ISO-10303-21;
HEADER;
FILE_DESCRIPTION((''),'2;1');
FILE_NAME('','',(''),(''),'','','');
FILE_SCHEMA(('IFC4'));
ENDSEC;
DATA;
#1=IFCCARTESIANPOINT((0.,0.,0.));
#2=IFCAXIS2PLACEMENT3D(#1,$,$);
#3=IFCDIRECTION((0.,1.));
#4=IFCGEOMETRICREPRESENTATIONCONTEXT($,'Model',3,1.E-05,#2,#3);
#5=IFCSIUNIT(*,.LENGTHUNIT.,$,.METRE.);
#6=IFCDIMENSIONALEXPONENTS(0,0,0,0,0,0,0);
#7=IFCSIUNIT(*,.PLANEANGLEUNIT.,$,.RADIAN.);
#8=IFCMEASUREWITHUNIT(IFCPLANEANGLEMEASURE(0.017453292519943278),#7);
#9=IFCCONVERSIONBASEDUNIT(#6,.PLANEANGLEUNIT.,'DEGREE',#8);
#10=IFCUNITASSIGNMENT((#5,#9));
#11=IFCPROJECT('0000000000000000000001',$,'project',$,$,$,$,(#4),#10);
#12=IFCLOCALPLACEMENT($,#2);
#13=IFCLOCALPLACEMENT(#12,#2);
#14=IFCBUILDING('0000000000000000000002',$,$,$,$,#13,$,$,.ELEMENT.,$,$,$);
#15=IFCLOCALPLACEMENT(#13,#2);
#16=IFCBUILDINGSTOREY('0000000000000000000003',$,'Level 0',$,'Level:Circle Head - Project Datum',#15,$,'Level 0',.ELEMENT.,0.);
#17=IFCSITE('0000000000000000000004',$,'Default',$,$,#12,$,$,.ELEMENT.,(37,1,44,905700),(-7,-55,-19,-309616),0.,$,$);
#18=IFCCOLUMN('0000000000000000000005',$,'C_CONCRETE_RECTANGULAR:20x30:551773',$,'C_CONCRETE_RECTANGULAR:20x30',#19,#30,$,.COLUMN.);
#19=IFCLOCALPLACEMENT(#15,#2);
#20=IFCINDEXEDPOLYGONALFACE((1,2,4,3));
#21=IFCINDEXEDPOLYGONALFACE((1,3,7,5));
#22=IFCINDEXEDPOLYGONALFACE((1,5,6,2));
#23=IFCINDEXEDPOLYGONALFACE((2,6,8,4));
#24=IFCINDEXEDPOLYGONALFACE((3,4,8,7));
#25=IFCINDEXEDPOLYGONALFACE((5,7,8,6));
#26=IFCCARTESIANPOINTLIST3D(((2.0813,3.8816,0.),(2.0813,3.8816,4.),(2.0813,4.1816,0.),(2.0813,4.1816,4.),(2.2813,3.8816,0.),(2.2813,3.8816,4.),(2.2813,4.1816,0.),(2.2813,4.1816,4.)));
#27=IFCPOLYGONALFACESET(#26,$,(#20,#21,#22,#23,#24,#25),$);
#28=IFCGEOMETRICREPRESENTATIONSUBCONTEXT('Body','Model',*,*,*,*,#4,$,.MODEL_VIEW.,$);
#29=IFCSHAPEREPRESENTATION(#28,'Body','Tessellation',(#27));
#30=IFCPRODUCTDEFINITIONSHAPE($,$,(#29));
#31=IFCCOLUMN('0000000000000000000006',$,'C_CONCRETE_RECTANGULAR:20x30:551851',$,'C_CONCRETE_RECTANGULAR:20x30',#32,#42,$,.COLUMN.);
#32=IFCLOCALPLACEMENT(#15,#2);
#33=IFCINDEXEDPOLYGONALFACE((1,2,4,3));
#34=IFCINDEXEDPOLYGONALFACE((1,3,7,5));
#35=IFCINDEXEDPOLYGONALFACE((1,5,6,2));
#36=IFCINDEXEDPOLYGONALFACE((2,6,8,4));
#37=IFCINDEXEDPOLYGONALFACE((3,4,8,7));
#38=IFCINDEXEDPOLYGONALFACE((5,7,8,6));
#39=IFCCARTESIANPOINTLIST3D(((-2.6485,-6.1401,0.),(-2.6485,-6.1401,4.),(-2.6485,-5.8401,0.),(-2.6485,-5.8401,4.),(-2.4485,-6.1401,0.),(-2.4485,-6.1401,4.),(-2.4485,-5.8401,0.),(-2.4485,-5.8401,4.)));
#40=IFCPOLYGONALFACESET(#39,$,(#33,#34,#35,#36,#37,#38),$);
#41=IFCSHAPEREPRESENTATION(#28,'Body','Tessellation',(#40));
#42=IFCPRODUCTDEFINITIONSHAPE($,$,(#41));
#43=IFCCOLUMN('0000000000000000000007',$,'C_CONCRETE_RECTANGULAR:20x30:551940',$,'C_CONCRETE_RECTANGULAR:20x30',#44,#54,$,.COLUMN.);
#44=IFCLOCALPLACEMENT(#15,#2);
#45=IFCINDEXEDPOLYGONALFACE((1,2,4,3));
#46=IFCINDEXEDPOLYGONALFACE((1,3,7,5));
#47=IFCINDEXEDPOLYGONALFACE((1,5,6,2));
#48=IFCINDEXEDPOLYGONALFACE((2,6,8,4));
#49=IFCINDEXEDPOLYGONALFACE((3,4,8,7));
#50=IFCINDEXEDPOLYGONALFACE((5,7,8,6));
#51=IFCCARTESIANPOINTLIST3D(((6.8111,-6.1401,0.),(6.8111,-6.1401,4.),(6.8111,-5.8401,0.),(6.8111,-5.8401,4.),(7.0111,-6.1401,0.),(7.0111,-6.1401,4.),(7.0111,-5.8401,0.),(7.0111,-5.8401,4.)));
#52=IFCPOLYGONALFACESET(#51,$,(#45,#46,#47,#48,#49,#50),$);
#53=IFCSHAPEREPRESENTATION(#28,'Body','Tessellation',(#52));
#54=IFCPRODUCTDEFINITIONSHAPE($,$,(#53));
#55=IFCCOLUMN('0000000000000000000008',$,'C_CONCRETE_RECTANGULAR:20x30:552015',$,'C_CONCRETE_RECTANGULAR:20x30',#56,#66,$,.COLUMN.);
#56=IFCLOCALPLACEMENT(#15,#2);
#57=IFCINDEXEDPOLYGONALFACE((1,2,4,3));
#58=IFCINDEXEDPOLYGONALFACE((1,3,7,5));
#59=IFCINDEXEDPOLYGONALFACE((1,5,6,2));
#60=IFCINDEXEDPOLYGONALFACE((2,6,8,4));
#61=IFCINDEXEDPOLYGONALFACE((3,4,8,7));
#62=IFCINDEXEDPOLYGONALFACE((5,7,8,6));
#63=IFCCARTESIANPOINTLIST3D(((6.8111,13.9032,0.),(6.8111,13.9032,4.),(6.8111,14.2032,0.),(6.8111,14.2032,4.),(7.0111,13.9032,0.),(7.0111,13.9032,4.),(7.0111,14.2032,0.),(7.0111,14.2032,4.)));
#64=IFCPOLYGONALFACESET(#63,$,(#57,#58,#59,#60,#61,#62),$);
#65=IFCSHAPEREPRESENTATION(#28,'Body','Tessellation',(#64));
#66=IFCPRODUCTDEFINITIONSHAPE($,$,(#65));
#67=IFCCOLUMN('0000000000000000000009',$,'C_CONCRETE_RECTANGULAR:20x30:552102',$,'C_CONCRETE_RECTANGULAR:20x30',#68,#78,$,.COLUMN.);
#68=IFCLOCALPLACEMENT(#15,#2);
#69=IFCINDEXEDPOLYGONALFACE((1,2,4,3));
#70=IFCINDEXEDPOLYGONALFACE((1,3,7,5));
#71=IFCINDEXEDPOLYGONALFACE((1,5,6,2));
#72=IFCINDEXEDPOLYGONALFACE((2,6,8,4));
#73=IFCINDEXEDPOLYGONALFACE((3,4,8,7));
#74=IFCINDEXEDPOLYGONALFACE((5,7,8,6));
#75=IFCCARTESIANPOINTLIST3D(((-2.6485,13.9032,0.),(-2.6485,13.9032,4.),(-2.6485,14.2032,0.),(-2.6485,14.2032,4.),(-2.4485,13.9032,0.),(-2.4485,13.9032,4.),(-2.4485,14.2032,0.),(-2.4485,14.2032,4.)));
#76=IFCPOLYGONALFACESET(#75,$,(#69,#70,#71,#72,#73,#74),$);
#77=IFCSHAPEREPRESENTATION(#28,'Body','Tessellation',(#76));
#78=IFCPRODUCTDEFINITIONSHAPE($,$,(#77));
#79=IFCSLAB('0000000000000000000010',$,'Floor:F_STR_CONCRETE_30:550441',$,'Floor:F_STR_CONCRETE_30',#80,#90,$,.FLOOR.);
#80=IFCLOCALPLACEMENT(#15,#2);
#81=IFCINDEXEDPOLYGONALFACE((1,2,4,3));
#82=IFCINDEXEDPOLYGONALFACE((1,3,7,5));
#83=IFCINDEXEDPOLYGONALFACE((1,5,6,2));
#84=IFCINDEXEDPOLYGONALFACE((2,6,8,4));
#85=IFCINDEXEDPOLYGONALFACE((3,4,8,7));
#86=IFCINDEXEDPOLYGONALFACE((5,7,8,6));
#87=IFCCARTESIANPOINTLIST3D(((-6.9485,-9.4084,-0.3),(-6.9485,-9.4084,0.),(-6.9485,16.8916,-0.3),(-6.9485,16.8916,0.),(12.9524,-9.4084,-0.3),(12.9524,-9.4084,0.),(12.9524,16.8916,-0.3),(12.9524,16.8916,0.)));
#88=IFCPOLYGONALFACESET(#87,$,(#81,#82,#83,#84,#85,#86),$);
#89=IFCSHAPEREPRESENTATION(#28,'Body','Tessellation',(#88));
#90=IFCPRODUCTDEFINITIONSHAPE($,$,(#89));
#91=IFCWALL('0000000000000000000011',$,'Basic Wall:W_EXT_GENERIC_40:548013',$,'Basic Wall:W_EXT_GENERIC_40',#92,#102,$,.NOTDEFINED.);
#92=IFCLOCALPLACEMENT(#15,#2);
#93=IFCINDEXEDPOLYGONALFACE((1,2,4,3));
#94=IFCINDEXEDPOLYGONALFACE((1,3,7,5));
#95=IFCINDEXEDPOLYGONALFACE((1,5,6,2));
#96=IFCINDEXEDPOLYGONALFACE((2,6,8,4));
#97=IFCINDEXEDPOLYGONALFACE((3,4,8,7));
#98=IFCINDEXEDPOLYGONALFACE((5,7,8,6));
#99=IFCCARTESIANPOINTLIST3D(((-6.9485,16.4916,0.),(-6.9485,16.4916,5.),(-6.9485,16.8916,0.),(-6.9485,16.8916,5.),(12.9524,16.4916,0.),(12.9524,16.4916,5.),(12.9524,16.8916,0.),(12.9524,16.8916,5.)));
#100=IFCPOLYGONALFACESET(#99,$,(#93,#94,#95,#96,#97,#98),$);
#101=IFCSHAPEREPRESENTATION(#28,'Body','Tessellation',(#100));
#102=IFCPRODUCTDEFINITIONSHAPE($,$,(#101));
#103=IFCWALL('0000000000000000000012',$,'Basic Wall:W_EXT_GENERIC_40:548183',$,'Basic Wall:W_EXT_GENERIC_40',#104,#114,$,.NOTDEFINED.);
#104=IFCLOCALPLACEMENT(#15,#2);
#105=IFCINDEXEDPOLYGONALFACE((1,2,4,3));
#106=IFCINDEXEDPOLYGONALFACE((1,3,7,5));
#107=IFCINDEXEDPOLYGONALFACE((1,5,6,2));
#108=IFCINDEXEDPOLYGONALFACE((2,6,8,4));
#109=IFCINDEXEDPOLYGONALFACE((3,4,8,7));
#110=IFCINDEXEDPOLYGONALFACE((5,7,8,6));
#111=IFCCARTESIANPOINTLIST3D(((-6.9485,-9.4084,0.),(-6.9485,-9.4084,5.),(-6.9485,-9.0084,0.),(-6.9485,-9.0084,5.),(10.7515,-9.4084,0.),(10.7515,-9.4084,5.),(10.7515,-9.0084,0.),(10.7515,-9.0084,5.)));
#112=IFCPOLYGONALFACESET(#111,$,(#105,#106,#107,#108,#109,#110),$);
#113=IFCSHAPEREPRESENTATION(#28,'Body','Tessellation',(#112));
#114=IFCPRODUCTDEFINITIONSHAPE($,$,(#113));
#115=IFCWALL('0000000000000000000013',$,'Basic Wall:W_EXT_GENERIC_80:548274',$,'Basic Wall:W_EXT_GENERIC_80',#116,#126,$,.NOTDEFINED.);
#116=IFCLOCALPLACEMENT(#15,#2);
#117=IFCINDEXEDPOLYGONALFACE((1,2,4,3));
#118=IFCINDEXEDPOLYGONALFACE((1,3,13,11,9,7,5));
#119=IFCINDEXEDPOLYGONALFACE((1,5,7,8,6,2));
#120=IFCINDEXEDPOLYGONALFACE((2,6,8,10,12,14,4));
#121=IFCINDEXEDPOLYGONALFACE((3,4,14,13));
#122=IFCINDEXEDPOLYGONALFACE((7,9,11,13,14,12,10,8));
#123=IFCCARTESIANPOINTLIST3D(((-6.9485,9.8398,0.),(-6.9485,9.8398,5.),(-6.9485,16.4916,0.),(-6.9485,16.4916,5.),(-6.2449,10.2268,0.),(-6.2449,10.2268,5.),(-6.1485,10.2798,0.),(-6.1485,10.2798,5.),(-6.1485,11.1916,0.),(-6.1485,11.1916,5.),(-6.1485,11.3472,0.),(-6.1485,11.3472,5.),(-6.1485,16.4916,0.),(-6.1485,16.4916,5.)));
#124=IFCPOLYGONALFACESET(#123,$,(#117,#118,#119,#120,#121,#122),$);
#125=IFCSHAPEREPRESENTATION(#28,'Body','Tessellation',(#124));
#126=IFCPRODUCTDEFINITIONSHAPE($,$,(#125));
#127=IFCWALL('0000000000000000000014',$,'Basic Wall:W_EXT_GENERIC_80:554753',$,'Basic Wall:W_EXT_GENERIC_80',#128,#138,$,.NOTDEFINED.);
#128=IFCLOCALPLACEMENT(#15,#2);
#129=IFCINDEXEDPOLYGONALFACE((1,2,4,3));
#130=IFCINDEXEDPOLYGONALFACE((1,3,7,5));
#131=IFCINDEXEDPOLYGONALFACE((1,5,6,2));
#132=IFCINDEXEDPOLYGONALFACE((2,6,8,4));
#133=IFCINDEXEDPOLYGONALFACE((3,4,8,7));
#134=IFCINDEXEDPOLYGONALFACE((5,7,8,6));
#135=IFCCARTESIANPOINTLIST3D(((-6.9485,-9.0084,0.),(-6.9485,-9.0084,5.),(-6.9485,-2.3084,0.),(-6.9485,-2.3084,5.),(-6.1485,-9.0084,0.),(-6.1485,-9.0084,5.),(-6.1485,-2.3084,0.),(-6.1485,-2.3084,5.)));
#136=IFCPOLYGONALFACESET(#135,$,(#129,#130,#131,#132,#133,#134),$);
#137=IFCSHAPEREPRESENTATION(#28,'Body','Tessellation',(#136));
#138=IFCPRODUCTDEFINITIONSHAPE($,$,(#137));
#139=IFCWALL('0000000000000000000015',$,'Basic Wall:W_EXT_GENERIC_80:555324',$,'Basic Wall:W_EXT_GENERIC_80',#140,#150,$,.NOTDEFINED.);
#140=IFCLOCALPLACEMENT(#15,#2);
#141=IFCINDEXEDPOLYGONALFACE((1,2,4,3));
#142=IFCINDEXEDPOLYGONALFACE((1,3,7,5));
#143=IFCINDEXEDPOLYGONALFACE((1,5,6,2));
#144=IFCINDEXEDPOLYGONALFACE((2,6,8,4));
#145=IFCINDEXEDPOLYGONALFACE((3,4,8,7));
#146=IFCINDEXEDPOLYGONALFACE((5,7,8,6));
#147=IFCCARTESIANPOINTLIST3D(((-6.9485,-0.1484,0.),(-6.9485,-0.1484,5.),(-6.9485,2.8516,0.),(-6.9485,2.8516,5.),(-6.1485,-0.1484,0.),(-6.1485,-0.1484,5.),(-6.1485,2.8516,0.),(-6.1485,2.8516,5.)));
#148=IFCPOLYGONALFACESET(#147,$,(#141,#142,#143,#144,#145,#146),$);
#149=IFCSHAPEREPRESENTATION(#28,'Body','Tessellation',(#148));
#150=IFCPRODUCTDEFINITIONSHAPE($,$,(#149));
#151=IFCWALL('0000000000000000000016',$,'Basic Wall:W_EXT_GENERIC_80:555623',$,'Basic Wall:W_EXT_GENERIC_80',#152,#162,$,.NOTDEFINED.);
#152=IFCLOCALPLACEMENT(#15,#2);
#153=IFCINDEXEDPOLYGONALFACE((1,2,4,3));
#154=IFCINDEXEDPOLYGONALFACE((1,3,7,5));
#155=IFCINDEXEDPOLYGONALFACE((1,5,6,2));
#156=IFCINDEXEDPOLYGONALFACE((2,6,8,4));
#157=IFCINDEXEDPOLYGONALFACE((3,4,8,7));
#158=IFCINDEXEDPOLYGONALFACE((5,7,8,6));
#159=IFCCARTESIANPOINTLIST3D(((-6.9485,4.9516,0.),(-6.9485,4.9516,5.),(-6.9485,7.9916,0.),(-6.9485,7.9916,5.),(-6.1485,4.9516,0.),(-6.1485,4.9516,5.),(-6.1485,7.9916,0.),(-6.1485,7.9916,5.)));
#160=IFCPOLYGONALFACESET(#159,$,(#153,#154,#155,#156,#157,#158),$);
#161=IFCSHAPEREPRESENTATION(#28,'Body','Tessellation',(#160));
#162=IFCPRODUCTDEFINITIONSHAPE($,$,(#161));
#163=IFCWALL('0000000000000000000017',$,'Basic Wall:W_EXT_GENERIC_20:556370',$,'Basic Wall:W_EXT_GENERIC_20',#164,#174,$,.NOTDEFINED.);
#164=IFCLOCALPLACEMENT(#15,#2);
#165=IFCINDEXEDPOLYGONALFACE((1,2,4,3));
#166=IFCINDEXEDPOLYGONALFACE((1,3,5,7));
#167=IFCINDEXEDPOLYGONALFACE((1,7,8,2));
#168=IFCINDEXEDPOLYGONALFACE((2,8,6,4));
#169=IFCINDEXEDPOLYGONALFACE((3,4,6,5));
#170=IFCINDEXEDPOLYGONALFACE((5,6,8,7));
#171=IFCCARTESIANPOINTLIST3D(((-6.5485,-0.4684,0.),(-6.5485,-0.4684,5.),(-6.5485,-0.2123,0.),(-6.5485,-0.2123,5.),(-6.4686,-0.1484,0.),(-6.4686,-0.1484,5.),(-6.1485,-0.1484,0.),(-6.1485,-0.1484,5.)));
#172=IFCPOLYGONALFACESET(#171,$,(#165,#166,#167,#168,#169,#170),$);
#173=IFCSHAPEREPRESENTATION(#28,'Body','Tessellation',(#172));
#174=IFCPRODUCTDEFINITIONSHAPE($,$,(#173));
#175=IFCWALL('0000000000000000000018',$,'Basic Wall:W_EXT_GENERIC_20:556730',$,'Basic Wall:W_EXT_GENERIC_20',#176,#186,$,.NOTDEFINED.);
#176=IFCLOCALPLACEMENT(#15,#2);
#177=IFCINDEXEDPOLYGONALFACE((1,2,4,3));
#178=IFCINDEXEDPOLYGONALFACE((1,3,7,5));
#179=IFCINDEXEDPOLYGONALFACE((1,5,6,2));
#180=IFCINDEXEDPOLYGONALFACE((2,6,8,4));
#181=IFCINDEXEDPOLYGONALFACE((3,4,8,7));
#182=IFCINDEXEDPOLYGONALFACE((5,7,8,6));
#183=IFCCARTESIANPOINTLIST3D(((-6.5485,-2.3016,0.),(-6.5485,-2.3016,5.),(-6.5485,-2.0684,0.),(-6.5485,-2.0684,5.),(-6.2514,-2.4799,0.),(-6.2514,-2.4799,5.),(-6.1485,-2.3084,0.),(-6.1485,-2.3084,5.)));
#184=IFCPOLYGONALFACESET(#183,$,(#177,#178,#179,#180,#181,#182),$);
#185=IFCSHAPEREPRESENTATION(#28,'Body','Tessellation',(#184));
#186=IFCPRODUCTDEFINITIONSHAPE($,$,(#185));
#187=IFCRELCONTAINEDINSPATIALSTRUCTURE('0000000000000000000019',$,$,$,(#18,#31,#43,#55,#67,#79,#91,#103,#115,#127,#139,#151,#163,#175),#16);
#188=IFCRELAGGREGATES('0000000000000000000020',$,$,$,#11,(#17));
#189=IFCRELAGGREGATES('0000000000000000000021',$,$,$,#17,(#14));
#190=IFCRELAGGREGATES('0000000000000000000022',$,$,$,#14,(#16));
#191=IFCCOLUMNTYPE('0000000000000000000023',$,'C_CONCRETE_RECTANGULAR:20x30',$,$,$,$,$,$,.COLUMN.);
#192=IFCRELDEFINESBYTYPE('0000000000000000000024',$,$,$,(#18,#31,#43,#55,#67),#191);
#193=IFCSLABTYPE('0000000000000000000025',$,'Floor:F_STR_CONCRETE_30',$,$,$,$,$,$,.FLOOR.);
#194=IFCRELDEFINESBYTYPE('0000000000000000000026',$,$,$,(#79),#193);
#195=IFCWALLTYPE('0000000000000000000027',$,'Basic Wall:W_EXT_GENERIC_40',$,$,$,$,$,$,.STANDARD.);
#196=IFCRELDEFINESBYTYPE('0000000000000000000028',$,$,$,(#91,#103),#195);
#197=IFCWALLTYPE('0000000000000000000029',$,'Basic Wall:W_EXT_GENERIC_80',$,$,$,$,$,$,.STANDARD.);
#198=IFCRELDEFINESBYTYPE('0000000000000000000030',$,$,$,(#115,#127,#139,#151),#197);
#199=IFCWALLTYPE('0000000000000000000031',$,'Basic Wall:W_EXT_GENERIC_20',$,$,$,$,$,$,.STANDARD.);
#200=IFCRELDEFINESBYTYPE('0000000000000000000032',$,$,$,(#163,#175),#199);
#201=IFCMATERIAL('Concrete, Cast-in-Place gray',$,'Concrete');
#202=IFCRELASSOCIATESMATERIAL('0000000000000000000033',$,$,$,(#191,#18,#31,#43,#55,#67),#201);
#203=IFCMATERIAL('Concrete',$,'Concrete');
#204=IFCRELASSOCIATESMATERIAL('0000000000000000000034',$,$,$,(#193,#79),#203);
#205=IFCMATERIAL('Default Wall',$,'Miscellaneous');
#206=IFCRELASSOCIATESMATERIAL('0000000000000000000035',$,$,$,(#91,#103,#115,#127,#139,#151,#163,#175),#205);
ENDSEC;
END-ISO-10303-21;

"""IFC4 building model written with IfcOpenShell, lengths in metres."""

from ifc_helpers import new_model, entity, si_unit, converted_unit, direction, frame, origin, place, context, subcontext, project, spatial, indexed_curve, outline, extrude, source, transform, mapped, material, type_object, type_shapes, element, save


model = new_model("IFC4")

# Units and contexts
model_context = context("Model", 3, precision=1e-05, world=origin(), true_north=direction((0.0, 1.0)))
body_context = subcontext(model_context, "Body", "Model", "MODEL_VIEW")
ifc_project = project(units=[si_unit("LENGTHUNIT", "METRE"), converted_unit("PLANEANGLEUNIT", "DEGREE", entity("IfcPlaneAngleMeasure", 0.017453292519943278), si_unit("PLANEANGLEUNIT", "RADIAN"), dimensions=[0, 0, 0, 0, 0, 0, 0])], contexts=[model_context])

# Site, building, storey
site_placement = place(None, origin())
site = spatial("IfcSite", under=ifc_project, at=site_placement, Name="Default", CompositionType="ELEMENT", RefLatitude=(37, 1, 44, 905700), RefLongitude=(-7, -55, -19, -309616), RefElevation=0.0)
building_placement = place(site_placement, origin())
building = spatial("IfcBuilding", under=site, at=building_placement, CompositionType="ELEMENT")
storey_placement = place(building_placement, origin())
storey = spatial("IfcBuildingStorey", under=building, at=storey_placement, Name="Level 0", ObjectType="Level:Circle Head - Project Datum", LongName="Level 0", CompositionType="ELEMENT", Elevation=0.0)

# Columns
ifc_material_1 = material(Name="Concrete, Cast-in-Place gray", Category="Concrete")
column_type = type_object("IfcColumnType", Name="C_CONCRETE_RECTANGULAR:20x30", PredefinedType="COLUMN", material=ifc_material_1)
shared_shape = source(origin(), body_context, "Body", "SweptSolid", [
    extrude(outline(indexed_curve([(-0.1, -0.15), (0.1, -0.15), (0.1, 0.15), (-0.1, 0.15), (-0.1, -0.15)], self_intersect=False)), frame((0.0, 0.0, 0.0), z_axis=(0.0, 0.0, 1.0), x_axis=(-1.0, 0.0, 0.0)), (0.0, 0.0, 1.0), 4.0),
])
type_shapes(column_type, [shared_shape])
for number, where, name in (
    (1, (2.1813, 4.0316, 0.0), "C_CONCRETE_RECTANGULAR:20x30:551773"),
    (2, (-2.5485, -5.9901, 0.0), "C_CONCRETE_RECTANGULAR:20x30:551851"),
    (3, (6.9111, -5.9901, 0.0), "C_CONCRETE_RECTANGULAR:20x30:551940"),
    (4, (6.9111, 14.0532, 0.0), "C_CONCRETE_RECTANGULAR:20x30:552015"),
    (5, (-2.5485, 14.0532, 0.0), "C_CONCRETE_RECTANGULAR:20x30:552102"),
):
    element("IfcColumn", number, at=place(storey_placement, frame(where)), inside=storey, type_object=column_type, material=ifc_material_1, Name=name, ObjectType="C_CONCRETE_RECTANGULAR:20x30", PredefinedType="COLUMN", context=body_context, shape_type="MappedRepresentation", body=[
        mapped(shared_shape, transform((0.0, 0.0, 0.0), scale=1.0)),
    ])

# Slab
ifc_material_2 = material(Name="Concrete", Category="Concrete")
slab_type = type_object("IfcSlabType", Name="Floor:F_STR_CONCRETE_30", PredefinedType="FLOOR", material=ifc_material_2)
slab_placement = place(storey_placement, origin())
element("IfcSlab", 6, at=slab_placement, inside=storey, type_object=slab_type, material=ifc_material_2, Name="Floor:F_STR_CONCRETE_30:550441", ObjectType="Floor:F_STR_CONCRETE_30", PredefinedType="FLOOR", context=body_context, shape_type="SweptSolid", body=[
    extrude(outline(indexed_curve([(-13.15, -9.9504), (13.15, -9.9504), (13.15, 9.9504), (-13.15, 9.9504), (-13.15, -9.9504)], self_intersect=False)), frame((3.0019, 3.7416, 0.0), z_axis=(0.0, 0.0, -1.0), x_axis=(0.0, 1.0, 0.0)), (0.0, 0.0, 1.0), 0.3),
])

# Walls
ifc_material_3 = material(Name="Default Wall", Category="Miscellaneous")
wall_type_1 = type_object("IfcWallType", Name="Basic Wall:W_EXT_GENERIC_40", PredefinedType="STANDARD")
wall_1_placement = place(storey_placement, frame((-6.9485, 16.6916, 0.0)))
element("IfcWall", 7, at=wall_1_placement, inside=storey, type_object=wall_type_1, material=ifc_material_3, Name="Basic Wall:W_EXT_GENERIC_40:548013", ObjectType="Basic Wall:W_EXT_GENERIC_40", PredefinedType="NOTDEFINED", context=body_context, shape_type="SweptSolid", body=[
    extrude(outline(indexed_curve([(19.9008, 0.2), (0.0, 0.2), (0.0, -0.2), (19.9008, -0.2), (19.9008, 0.2)], self_intersect=False)), origin(), (0.0, 0.0, 1.0), 5.0),
])
wall_2_placement = place(storey_placement, frame((10.7515, -9.2084, 0.0), z_axis=(0.0, 0.0, 1.0), x_axis=(-1.0, 0.0, 0.0)))
element("IfcWall", 8, at=wall_2_placement, inside=storey, type_object=wall_type_1, material=ifc_material_3, Name="Basic Wall:W_EXT_GENERIC_40:548183", ObjectType="Basic Wall:W_EXT_GENERIC_40", PredefinedType="NOTDEFINED", context=body_context, shape_type="SweptSolid", body=[
    extrude(outline(indexed_curve([(17.7, 0.2), (0.0, 0.2), (0.0, -0.2), (17.7, -0.2), (17.7, 0.2)], self_intersect=False)), origin(), (0.0, 0.0, 1.0), 5.0),
])
wall_type_2 = type_object("IfcWallType", Name="Basic Wall:W_EXT_GENERIC_80", PredefinedType="STANDARD")
wall_3_placement = place(storey_placement, frame((-6.5485, 16.4916, 0.0), z_axis=(0.0, 0.0, 1.0), x_axis=(0.0, -1.0, 0.0)))
element("IfcWall", 9, at=wall_3_placement, inside=storey, type_object=wall_type_2, material=ifc_material_3, Name="Basic Wall:W_EXT_GENERIC_80:548274", ObjectType="Basic Wall:W_EXT_GENERIC_80", PredefinedType="NOTDEFINED", context=body_context, shape_type="SweptSolid", body=[
    extrude(outline(indexed_curve([(6.6517, -0.4), (6.2648, 0.3036), (6.2117, 0.4), (5.3, 0.4), (5.1444, 0.4), (0.0, 0.4), (0.0, -0.4), (6.6517, -0.4)], self_intersect=False)), origin(), (0.0, 0.0, 1.0), 5.0),
])
wall_4_placement = place(storey_placement, frame((-6.5485, -2.3084, 0.0), z_axis=(0.0, 0.0, 1.0), x_axis=(0.0, -1.0, 0.0)))
element("IfcWall", 10, at=wall_4_placement, inside=storey, type_object=wall_type_2, material=ifc_material_3, Name="Basic Wall:W_EXT_GENERIC_80:554753", ObjectType="Basic Wall:W_EXT_GENERIC_80", PredefinedType="NOTDEFINED", context=body_context, shape_type="SweptSolid", body=[
    extrude(outline(indexed_curve([(6.7, 0.4), (0.0, 0.4), (0.0, -0.4), (6.7, -0.4), (6.7, 0.4)], self_intersect=False)), origin(), (0.0, 0.0, 1.0), 5.0),
])
wall_5_placement = place(storey_placement, frame((-6.5485, 2.8516, 0.0), z_axis=(0.0, 0.0, 1.0), x_axis=(0.0, -1.0, 0.0)))
element("IfcWall", 11, at=wall_5_placement, inside=storey, type_object=wall_type_2, material=ifc_material_3, Name="Basic Wall:W_EXT_GENERIC_80:555324", ObjectType="Basic Wall:W_EXT_GENERIC_80", PredefinedType="NOTDEFINED", context=body_context, shape_type="SweptSolid", body=[
    extrude(outline(indexed_curve([(3.0, 0.4), (0.0, 0.4), (0.0, -0.4), (3.0, -0.4), (3.0, 0.4)], self_intersect=False)), origin(), (0.0, 0.0, 1.0), 5.0),
])
wall_6_placement = place(storey_placement, frame((-6.5485, 7.9916, 0.0), z_axis=(0.0, 0.0, 1.0), x_axis=(0.0, -1.0, 0.0)))
element("IfcWall", 12, at=wall_6_placement, inside=storey, type_object=wall_type_2, material=ifc_material_3, Name="Basic Wall:W_EXT_GENERIC_80:555623", ObjectType="Basic Wall:W_EXT_GENERIC_80", PredefinedType="NOTDEFINED", context=body_context, shape_type="SweptSolid", body=[
    extrude(outline(indexed_curve([(3.04, 0.4), (0.0, 0.4), (0.0, -0.4), (3.04, -0.4), (3.04, 0.4)], self_intersect=False)), origin(), (0.0, 0.0, 1.0), 5.0),
])
wall_type_3 = type_object("IfcWallType", Name="Basic Wall:W_EXT_GENERIC_20", PredefinedType="STANDARD")
wall_7_placement = place(storey_placement, frame((-6.2109, -0.0703, 0.0), z_axis=(0.0, 0.0, 1.0), x_axis=(-0.780869, -0.624695, 0.0)))
element("IfcWall", 13, at=wall_7_placement, inside=storey, type_object=wall_type_3, material=ifc_material_3, Name="Basic Wall:W_EXT_GENERIC_20:556370", ObjectType="Basic Wall:W_EXT_GENERIC_20", PredefinedType="NOTDEFINED", context=body_context, shape_type="SweptSolid", body=[
    extrude(outline(indexed_curve([(0.0, 0.1), (0.25, -0.1), (0.3522, -0.1), (0.5122, 0.1), (0.0, 0.1)], self_intersect=False)), origin(), (0.0, 0.0, 1.0), 5.0),
])
wall_8_placement = place(storey_placement, frame((-6.1999, -2.3942, 0.0), z_axis=(0.0, 0.0, 1.0), x_axis=(-0.857493, 0.514496, 0.0)))
element("IfcWall", 14, at=wall_8_placement, inside=storey, type_object=wall_type_3, material=ifc_material_3, Name="Basic Wall:W_EXT_GENERIC_20:556730", ObjectType="Basic Wall:W_EXT_GENERIC_20", PredefinedType="NOTDEFINED", context=body_context, shape_type="SweptSolid", body=[
    extrude(outline(indexed_curve([(0.4665, -0.1), (0.3465, 0.1), (0.0, 0.1), (0.0, -0.1), (0.4665, -0.1)], self_intersect=False)), origin(), (0.0, 0.0, 1.0), 5.0),
])

save(model, "model.ifc")
